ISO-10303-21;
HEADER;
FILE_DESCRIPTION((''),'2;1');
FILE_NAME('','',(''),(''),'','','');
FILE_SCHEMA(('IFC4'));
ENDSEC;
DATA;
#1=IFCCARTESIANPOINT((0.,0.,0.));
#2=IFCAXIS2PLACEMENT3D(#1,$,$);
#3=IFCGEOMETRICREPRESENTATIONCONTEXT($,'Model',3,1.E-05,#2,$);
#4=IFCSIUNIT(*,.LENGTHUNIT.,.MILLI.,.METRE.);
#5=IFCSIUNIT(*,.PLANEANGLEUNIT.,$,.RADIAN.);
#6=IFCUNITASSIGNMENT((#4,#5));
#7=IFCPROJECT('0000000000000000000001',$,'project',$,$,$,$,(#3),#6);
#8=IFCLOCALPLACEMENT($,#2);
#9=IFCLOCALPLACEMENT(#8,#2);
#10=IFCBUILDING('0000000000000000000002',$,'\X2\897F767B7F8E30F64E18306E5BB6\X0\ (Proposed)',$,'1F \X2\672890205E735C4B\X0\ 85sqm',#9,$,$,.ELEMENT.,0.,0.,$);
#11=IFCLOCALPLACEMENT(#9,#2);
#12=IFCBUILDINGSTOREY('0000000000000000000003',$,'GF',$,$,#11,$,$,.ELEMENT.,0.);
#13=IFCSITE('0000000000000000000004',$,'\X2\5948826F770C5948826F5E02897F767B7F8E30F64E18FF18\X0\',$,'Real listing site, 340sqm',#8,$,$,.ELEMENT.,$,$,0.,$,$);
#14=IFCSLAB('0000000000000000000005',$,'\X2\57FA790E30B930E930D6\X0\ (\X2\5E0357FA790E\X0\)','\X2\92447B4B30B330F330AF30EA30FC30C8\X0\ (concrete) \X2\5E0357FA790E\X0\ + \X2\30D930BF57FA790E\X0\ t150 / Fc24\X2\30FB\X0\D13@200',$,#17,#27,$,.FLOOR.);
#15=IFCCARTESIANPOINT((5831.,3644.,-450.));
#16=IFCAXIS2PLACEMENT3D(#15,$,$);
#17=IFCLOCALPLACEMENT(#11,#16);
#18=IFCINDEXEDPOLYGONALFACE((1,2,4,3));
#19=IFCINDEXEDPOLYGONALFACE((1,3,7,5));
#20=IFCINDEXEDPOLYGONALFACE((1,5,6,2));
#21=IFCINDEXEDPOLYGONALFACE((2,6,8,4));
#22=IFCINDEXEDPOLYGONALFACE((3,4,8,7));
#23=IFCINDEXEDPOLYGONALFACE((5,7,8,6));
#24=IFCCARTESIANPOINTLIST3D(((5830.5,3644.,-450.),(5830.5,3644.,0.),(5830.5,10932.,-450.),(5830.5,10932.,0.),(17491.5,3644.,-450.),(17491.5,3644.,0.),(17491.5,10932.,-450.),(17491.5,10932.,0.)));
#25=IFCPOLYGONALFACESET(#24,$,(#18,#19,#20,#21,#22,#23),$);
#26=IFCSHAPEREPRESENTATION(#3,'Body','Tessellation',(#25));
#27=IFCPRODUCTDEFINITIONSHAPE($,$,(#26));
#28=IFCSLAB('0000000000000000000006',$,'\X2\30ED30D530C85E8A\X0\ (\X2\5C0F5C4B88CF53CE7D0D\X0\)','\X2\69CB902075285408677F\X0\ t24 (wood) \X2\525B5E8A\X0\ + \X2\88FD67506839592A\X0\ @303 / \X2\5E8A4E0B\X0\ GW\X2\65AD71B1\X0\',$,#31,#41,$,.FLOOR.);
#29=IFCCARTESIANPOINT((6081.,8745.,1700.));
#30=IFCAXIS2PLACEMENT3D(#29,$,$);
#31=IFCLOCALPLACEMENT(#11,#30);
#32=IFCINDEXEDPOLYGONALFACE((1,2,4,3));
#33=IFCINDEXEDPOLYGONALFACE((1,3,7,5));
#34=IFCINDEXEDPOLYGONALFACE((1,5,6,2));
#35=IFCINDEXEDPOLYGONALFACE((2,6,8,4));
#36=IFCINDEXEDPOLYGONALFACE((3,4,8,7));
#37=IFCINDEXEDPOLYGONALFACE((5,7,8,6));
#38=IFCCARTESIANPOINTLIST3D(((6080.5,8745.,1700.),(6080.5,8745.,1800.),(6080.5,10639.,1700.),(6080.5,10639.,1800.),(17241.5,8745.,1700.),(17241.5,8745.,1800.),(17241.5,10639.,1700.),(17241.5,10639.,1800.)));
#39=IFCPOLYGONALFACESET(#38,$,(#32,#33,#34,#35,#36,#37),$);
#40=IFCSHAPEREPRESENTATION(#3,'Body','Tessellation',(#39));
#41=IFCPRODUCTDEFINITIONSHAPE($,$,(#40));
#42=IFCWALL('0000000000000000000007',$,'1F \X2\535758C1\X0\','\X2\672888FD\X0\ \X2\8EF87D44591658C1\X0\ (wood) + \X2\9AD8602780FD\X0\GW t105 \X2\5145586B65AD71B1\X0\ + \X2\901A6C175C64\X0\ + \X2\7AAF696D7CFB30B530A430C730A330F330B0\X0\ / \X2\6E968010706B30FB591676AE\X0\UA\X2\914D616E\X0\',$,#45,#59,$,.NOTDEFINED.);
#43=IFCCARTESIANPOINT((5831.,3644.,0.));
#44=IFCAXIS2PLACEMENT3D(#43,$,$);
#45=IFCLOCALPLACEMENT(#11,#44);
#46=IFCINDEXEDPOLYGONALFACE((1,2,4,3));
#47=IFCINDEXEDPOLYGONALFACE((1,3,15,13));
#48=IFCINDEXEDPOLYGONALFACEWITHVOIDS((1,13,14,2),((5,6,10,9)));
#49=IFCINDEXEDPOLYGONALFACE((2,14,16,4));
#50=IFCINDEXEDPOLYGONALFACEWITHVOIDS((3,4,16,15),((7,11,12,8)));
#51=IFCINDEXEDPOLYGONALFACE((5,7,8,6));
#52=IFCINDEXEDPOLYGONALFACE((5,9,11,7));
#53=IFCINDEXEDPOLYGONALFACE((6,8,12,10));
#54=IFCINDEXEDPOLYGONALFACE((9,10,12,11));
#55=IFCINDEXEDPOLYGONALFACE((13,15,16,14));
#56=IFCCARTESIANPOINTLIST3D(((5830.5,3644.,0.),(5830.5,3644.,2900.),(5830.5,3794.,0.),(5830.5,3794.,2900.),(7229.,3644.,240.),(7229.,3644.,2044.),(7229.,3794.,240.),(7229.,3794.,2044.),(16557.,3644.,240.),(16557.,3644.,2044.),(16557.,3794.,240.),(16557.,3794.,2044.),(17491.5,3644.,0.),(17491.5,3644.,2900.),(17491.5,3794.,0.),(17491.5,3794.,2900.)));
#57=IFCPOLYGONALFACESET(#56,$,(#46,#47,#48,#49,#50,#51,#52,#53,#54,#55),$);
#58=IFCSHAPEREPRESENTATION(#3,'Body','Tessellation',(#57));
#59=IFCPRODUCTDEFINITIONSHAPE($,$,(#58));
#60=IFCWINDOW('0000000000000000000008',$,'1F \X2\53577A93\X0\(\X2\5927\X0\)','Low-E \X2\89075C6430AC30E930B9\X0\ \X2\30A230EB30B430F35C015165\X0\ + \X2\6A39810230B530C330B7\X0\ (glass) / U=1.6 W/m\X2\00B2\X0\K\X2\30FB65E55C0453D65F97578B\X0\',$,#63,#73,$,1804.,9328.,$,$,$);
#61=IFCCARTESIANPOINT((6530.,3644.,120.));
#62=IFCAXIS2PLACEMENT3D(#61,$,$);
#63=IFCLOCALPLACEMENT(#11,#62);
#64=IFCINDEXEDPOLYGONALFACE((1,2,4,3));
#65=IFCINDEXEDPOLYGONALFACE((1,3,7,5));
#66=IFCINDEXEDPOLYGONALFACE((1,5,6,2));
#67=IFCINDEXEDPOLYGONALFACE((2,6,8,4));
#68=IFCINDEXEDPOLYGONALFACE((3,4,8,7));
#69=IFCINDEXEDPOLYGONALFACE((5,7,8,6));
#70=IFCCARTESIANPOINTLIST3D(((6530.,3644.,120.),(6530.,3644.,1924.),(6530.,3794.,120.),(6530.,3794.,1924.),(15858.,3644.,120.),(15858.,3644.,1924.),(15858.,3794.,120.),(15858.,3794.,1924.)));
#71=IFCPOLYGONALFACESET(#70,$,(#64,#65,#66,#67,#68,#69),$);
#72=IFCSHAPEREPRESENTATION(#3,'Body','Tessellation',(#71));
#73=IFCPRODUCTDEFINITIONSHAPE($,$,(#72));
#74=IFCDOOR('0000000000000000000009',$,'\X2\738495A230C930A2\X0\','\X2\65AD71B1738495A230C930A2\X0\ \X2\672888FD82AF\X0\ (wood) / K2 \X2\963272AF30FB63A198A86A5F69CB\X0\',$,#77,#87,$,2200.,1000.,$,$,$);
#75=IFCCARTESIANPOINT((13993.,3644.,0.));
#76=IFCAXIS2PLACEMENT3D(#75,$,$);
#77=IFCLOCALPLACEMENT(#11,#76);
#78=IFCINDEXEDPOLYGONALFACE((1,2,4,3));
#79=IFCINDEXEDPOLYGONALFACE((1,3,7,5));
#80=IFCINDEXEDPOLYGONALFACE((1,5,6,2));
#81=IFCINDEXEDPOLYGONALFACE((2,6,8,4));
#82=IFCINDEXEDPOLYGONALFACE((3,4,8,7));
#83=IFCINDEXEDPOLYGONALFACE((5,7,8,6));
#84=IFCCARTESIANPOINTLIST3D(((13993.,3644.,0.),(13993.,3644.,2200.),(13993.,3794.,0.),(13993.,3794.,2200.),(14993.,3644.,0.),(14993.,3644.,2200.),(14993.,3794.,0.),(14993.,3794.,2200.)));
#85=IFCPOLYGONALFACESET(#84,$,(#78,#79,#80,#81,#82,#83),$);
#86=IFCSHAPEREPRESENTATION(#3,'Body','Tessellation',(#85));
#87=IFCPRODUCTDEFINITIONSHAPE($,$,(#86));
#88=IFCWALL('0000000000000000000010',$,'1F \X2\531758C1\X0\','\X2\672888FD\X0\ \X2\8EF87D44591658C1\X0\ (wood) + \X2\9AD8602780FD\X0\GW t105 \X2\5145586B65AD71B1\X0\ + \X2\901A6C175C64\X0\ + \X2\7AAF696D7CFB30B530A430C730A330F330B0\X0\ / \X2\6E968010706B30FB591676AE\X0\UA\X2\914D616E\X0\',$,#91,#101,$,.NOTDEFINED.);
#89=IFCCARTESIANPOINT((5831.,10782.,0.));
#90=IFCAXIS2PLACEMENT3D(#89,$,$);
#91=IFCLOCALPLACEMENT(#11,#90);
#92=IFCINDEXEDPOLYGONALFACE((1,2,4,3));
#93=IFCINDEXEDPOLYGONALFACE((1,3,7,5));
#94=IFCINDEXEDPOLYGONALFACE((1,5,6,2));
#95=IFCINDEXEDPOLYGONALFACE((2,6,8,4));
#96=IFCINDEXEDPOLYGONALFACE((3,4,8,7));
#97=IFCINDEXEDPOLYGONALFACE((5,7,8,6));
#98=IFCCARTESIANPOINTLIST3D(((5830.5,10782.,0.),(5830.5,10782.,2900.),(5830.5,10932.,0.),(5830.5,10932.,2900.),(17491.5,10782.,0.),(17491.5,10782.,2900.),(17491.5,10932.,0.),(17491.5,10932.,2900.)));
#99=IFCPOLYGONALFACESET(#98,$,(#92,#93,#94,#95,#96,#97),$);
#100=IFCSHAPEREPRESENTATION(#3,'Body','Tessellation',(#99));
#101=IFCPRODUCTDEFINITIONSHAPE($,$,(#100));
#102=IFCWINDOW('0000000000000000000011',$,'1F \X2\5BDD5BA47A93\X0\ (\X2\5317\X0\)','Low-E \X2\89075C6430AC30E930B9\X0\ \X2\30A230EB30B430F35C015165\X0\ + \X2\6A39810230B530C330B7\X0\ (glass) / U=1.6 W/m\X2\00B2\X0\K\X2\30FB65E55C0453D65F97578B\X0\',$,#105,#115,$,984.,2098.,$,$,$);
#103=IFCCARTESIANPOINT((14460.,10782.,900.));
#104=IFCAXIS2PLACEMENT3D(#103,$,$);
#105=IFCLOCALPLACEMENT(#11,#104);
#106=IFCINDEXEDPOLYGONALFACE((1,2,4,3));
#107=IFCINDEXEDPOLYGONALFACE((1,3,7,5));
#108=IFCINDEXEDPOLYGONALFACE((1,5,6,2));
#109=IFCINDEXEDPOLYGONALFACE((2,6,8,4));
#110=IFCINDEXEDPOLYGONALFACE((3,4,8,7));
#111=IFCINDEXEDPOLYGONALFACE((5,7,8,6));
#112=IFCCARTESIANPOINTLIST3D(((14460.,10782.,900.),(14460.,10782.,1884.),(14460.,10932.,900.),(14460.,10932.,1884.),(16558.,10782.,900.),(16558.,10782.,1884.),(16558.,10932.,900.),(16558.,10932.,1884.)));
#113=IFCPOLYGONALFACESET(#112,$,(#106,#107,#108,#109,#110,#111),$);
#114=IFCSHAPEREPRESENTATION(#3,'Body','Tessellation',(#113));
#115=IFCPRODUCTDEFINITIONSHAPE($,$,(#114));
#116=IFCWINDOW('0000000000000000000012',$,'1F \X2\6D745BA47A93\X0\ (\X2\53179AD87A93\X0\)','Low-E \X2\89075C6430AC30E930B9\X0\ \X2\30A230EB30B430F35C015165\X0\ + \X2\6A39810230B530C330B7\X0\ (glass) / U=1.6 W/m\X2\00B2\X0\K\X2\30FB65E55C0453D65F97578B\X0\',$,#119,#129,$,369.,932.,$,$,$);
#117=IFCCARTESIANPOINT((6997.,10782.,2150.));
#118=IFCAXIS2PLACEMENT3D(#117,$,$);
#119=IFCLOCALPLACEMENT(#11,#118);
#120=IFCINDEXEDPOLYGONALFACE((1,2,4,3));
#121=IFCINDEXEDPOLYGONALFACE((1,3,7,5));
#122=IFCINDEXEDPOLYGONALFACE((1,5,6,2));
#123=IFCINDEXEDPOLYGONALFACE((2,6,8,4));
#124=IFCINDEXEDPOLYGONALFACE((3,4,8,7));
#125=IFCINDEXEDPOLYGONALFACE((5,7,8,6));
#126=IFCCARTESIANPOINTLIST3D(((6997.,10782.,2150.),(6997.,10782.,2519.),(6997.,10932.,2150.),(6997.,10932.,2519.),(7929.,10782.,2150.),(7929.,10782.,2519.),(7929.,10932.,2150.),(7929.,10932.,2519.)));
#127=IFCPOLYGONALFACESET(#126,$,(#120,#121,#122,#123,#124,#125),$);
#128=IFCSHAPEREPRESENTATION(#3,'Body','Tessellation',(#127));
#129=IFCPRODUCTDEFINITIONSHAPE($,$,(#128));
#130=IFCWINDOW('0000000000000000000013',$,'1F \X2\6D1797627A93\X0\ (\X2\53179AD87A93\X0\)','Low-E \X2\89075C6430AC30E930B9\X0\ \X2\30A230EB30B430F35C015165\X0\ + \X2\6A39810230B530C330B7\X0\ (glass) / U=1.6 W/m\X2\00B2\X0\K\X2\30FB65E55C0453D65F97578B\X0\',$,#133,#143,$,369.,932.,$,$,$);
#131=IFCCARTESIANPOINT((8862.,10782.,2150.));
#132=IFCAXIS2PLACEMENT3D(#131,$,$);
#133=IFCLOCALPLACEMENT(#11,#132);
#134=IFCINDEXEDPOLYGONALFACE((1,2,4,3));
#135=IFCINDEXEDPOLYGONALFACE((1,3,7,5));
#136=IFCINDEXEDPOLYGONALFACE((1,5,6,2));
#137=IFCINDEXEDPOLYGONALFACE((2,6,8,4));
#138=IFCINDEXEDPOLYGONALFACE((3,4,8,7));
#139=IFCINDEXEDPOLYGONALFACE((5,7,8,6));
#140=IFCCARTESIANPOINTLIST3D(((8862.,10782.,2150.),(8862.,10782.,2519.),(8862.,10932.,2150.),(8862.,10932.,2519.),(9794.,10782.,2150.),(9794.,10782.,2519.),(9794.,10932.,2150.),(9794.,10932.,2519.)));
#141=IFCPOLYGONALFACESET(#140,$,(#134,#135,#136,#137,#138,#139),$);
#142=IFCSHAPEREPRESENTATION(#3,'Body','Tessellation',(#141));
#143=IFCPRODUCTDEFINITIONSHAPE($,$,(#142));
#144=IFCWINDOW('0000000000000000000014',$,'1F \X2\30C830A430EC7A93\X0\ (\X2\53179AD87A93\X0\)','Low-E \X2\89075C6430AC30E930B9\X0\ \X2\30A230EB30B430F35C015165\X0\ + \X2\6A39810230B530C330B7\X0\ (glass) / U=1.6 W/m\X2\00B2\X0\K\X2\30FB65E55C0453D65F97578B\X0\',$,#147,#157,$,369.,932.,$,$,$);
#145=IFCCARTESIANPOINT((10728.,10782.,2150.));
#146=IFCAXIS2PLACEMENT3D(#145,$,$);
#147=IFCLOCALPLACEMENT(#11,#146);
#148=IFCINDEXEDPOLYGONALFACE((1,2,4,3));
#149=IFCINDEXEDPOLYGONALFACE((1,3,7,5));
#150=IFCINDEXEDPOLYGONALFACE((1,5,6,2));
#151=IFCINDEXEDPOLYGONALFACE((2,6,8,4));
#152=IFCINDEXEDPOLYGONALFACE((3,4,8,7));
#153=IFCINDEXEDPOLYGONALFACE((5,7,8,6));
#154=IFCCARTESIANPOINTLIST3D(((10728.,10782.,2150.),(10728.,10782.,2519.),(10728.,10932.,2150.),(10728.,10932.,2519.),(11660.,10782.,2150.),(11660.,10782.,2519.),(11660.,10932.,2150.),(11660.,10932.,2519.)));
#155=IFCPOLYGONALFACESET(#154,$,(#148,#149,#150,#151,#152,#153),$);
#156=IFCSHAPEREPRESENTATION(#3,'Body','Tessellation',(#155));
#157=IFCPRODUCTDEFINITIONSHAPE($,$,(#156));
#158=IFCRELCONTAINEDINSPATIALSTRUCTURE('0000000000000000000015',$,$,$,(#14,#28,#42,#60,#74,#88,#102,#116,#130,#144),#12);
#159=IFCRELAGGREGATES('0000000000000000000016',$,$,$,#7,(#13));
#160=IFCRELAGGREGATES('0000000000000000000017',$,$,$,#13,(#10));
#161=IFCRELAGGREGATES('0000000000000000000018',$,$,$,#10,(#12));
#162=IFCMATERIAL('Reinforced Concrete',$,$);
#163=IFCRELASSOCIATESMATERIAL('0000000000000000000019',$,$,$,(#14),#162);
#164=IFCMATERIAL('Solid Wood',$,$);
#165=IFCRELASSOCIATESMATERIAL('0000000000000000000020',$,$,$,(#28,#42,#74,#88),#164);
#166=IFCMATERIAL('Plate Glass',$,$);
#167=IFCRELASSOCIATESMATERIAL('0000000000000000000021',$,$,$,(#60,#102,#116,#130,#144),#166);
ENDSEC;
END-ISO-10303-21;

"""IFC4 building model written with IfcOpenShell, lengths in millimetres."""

from ifc_helpers import new_model, si_unit, frame, frame_2d, origin, place, context, project, spatial, rectangle, extrude, material, element, fill, save


model = new_model("IFC4")

# Units and contexts
model_context = context("Model", 3, precision=1e-05, world=origin())
ifc_project = project(units=[si_unit("LENGTHUNIT", "METRE", prefix="MILLI"), si_unit("PLANEANGLEUNIT", "RADIAN")], contexts=[model_context])

# Site, building, storey
site_placement = place(None, origin())
site = spatial("IfcSite", under=ifc_project, at=site_placement, Name="奈良県奈良市西登美ヶ丘８", ObjectType="Real listing site, 340sqm", CompositionType="ELEMENT", RefElevation=0.0)
building_placement = place(site_placement, origin())
building = spatial("IfcBuilding", under=site, at=building_placement, Name="西登美ヶ丘の家 (Proposed)", ObjectType="1F 木造平屋 85sqm", CompositionType="ELEMENT", ElevationOfRefHeight=0.0, ElevationOfTerrain=0.0)
storey_placement = place(building_placement, origin())
storey = spatial("IfcBuildingStorey", under=building, at=storey_placement, Name="GF", CompositionType="ELEMENT", Elevation=0.0)

# Slabs
ifc_material_1 = material(Name="Reinforced Concrete")
slab_1_placement = place(storey_placement, frame((5831.0, 3644.0, -450.0)))
element("IfcSlab", 1, at=slab_1_placement, inside=storey, material=ifc_material_1, Name="基礎スラブ (布基礎)", Description="鉄筋コンクリート (concrete) 布基礎 + ベタ基礎 t150 / Fc24・D13@200", PredefinedType="FLOOR", context=model_context, shape_type="SweptSolid", body=[
    extrude(rectangle(XDim=11661.0, YDim=7288.0, at=frame_2d((5830.0, 3644.0))), frame((5831.0, 3644.0, -450.0)), (0.0, 0.0, 1.0), 450.0),
])
ifc_material_2 = material(Name="Solid Wood")
slab_2_placement = place(storey_placement, frame((6081.0, 8745.0, 1700.0)))
element("IfcSlab", 2, at=slab_2_placement, inside=storey, material=ifc_material_2, Name="ロフト床 (小屋裏収納)", Description="構造用合板 t24 (wood) 剛床 + 製材根太 @303 / 床下 GW断熱", PredefinedType="FLOOR", context=model_context, shape_type="SweptSolid", body=[
    extrude(rectangle(XDim=11161.0, YDim=1894.0, at=frame_2d((5580.0, 947.0))), frame((6081.0, 8745.0, 1700.0)), (0.0, 0.0, 1.0), 100.0),
])

# Wall, openings, window, door
wall_1_placement = place(storey_placement, frame((5831.0, 3644.0, 0.0)))
wall_1 = element("IfcWall", 3, at=wall_1_placement, inside=storey, material=ifc_material_2, Name="1F 南壁", Description="木製 軸組外壁 (wood) + 高性能GW t105 充填断熱 + 通気層 + 窯業系サイディング / 準耐火・外皮UA配慮", PredefinedType="NOTDEFINED", context=model_context, shape_type="SweptSolid", body=[
    extrude(rectangle(XDim=11661.0, YDim=150.0, at=frame_2d((5830.0, 75.0))), frame((5831.0, 3644.0, 0.0)), (0.0, 0.0, 1.0), 2900.0),
])
opening_1_placement = place(storey_placement, frame((6530.0, 3644.0, 120.0)))
opening_1 = element("IfcOpeningElement", 4, at=opening_1_placement, cuts=wall_1, PredefinedType="NOTDEFINED", context=model_context, shape_type="SweptSolid", body=[
    extrude(rectangle(XDim=9328.0, YDim=150.0, at=frame_2d((4664.0, 75.0))), frame((6530.0, 3644.0, 120.0)), (0.0, 0.0, 1.0), 1804.0),
])
opening_2_placement = place(storey_placement, frame((13993.0, 3644.0, 0.0)))
opening_2 = element("IfcOpeningElement", 5, at=opening_2_placement, cuts=wall_1, PredefinedType="NOTDEFINED", context=model_context, shape_type="SweptSolid", body=[
    extrude(rectangle(XDim=1000.0, YDim=150.0, at=frame_2d((500.0, 75.0))), frame((13993.0, 3644.0, 0.0)), (0.0, 0.0, 1.0), 2200.0),
])
ifc_material_3 = material(Name="Plate Glass")
window_1_placement = place(storey_placement, frame((6530.0, 3644.0, 120.0)))
window_1 = element("IfcWindow", 6, at=window_1_placement, inside=storey, material=ifc_material_3, Name="1F 南窓(大)", Description="Low-E 複層ガラス アルゴン封入 + 樹脂サッシ (glass) / U=1.6 W/m²K・日射取得型", OverallHeight=1804.0, OverallWidth=9328.0, context=model_context, shape_type="SweptSolid", body=[
    extrude(rectangle(XDim=9328.0, YDim=150.0, at=frame_2d((4664.0, 75.0))), frame((6530.0, 3644.0, 120.0)), (0.0, 0.0, 1.0), 1804.0),
])
fill(opening_1, window_1)
door_1_placement = place(storey_placement, frame((13993.0, 3644.0, 0.0)))
door_1 = element("IfcDoor", 7, at=door_1_placement, inside=storey, material=ifc_material_2, Name="玄関ドア", Description="断熱玄関ドア 木製芯 (wood) / K2 防犯・採風機構", OverallHeight=2200.0, OverallWidth=1000.0, context=model_context, shape_type="SweptSolid", body=[
    extrude(rectangle(XDim=1000.0, YDim=150.0, at=frame_2d((500.0, 75.0))), frame((13993.0, 3644.0, 0.0)), (0.0, 0.0, 1.0), 2200.0),
])
fill(opening_2, door_1)

# Wall, openings, windows
wall_2_placement = place(storey_placement, frame((5831.0, 10782.0, 0.0)))
wall_2 = element("IfcWall", 8, at=wall_2_placement, inside=storey, material=ifc_material_2, Name="1F 北壁", Description="木製 軸組外壁 (wood) + 高性能GW t105 充填断熱 + 通気層 + 窯業系サイディング / 準耐火・外皮UA配慮", PredefinedType="NOTDEFINED", context=model_context, shape_type="SweptSolid", body=[
    extrude(rectangle(XDim=11661.0, YDim=150.0, at=frame_2d((5830.0, 75.0))), frame((5831.0, 10782.0, 0.0)), (0.0, 0.0, 1.0), 2900.0),
])
opening_3_placement = place(storey_placement, frame((14460.0, 10782.0, 900.0)))
opening_3 = element("IfcOpeningElement", 9, at=opening_3_placement, cuts=wall_2, PredefinedType="NOTDEFINED", context=model_context, shape_type="SweptSolid", body=[
    extrude(rectangle(XDim=2098.0, YDim=150.0, at=frame_2d((1049.0, 75.0))), frame((14460.0, 10782.0, 900.0)), (0.0, 0.0, 1.0), 984.0),
])
opening_4_placement = place(storey_placement, frame((6997.0, 10782.0, 2150.0)))
opening_4 = element("IfcOpeningElement", 10, at=opening_4_placement, cuts=wall_2, PredefinedType="NOTDEFINED", context=model_context, shape_type="SweptSolid", body=[
    extrude(rectangle(XDim=932.0, YDim=150.0, at=frame_2d((466.0, 75.0))), frame((6997.0, 10782.0, 2150.0)), (0.0, 0.0, 1.0), 369.0),
])
opening_5_placement = place(storey_placement, frame((8862.0, 10782.0, 2150.0)))
opening_5 = element("IfcOpeningElement", 11, at=opening_5_placement, cuts=wall_2, PredefinedType="NOTDEFINED", context=model_context, shape_type="SweptSolid", body=[
    extrude(rectangle(XDim=932.0, YDim=150.0, at=frame_2d((466.0, 75.0))), frame((8862.0, 10782.0, 2150.0)), (0.0, 0.0, 1.0), 369.0),
])
opening_6_placement = place(storey_placement, frame((10728.0, 10782.0, 2150.0)))
opening_6 = element("IfcOpeningElement", 12, at=opening_6_placement, cuts=wall_2, PredefinedType="NOTDEFINED", context=model_context, shape_type="SweptSolid", body=[
    extrude(rectangle(XDim=932.0, YDim=150.0, at=frame_2d((466.0, 75.0))), frame((10728.0, 10782.0, 2150.0)), (0.0, 0.0, 1.0), 369.0),
])
window_2_placement = place(storey_placement, frame((14460.0, 10782.0, 900.0)))
window_2 = element("IfcWindow", 13, at=window_2_placement, inside=storey, material=ifc_material_3, Name="1F 寝室窓 (北)", Description="Low-E 複層ガラス アルゴン封入 + 樹脂サッシ (glass) / U=1.6 W/m²K・日射取得型", OverallHeight=984.0, OverallWidth=2098.0, context=model_context, shape_type="SweptSolid", body=[
    extrude(rectangle(XDim=2098.0, YDim=150.0, at=frame_2d((1049.0, 75.0))), frame((14460.0, 10782.0, 900.0)), (0.0, 0.0, 1.0), 984.0),
])
fill(opening_3, window_2)
window_3_placement = place(storey_placement, frame((6997.0, 10782.0, 2150.0)))
window_3 = element("IfcWindow", 14, at=window_3_placement, inside=storey, material=ifc_material_3, Name="1F 浴室窓 (北高窓)", Description="Low-E 複層ガラス アルゴン封入 + 樹脂サッシ (glass) / U=1.6 W/m²K・日射取得型", OverallHeight=369.0, OverallWidth=932.0, context=model_context, shape_type="SweptSolid", body=[
    extrude(rectangle(XDim=932.0, YDim=150.0, at=frame_2d((466.0, 75.0))), frame((6997.0, 10782.0, 2150.0)), (0.0, 0.0, 1.0), 369.0),
])
fill(opening_4, window_3)
window_4_placement = place(storey_placement, frame((8862.0, 10782.0, 2150.0)))
window_4 = element("IfcWindow", 15, at=window_4_placement, inside=storey, material=ifc_material_3, Name="1F 洗面窓 (北高窓)", Description="Low-E 複層ガラス アルゴン封入 + 樹脂サッシ (glass) / U=1.6 W/m²K・日射取得型", OverallHeight=369.0, OverallWidth=932.0, context=model_context, shape_type="SweptSolid", body=[
    extrude(rectangle(XDim=932.0, YDim=150.0, at=frame_2d((466.0, 75.0))), frame((8862.0, 10782.0, 2150.0)), (0.0, 0.0, 1.0), 369.0),
])
fill(opening_5, window_4)
window_5_placement = place(storey_placement, frame((10728.0, 10782.0, 2150.0)))
window_5 = element("IfcWindow", 16, at=window_5_placement, inside=storey, material=ifc_material_3, Name="1F トイレ窓 (北高窓)", Description="Low-E 複層ガラス アルゴン封入 + 樹脂サッシ (glass) / U=1.6 W/m²K・日射取得型", OverallHeight=369.0, OverallWidth=932.0, context=model_context, shape_type="SweptSolid", body=[
    extrude(rectangle(XDim=932.0, YDim=150.0, at=frame_2d((466.0, 75.0))), frame((10728.0, 10782.0, 2150.0)), (0.0, 0.0, 1.0), 369.0),
])
fill(opening_6, window_5)

save(model, "model.ifc")
